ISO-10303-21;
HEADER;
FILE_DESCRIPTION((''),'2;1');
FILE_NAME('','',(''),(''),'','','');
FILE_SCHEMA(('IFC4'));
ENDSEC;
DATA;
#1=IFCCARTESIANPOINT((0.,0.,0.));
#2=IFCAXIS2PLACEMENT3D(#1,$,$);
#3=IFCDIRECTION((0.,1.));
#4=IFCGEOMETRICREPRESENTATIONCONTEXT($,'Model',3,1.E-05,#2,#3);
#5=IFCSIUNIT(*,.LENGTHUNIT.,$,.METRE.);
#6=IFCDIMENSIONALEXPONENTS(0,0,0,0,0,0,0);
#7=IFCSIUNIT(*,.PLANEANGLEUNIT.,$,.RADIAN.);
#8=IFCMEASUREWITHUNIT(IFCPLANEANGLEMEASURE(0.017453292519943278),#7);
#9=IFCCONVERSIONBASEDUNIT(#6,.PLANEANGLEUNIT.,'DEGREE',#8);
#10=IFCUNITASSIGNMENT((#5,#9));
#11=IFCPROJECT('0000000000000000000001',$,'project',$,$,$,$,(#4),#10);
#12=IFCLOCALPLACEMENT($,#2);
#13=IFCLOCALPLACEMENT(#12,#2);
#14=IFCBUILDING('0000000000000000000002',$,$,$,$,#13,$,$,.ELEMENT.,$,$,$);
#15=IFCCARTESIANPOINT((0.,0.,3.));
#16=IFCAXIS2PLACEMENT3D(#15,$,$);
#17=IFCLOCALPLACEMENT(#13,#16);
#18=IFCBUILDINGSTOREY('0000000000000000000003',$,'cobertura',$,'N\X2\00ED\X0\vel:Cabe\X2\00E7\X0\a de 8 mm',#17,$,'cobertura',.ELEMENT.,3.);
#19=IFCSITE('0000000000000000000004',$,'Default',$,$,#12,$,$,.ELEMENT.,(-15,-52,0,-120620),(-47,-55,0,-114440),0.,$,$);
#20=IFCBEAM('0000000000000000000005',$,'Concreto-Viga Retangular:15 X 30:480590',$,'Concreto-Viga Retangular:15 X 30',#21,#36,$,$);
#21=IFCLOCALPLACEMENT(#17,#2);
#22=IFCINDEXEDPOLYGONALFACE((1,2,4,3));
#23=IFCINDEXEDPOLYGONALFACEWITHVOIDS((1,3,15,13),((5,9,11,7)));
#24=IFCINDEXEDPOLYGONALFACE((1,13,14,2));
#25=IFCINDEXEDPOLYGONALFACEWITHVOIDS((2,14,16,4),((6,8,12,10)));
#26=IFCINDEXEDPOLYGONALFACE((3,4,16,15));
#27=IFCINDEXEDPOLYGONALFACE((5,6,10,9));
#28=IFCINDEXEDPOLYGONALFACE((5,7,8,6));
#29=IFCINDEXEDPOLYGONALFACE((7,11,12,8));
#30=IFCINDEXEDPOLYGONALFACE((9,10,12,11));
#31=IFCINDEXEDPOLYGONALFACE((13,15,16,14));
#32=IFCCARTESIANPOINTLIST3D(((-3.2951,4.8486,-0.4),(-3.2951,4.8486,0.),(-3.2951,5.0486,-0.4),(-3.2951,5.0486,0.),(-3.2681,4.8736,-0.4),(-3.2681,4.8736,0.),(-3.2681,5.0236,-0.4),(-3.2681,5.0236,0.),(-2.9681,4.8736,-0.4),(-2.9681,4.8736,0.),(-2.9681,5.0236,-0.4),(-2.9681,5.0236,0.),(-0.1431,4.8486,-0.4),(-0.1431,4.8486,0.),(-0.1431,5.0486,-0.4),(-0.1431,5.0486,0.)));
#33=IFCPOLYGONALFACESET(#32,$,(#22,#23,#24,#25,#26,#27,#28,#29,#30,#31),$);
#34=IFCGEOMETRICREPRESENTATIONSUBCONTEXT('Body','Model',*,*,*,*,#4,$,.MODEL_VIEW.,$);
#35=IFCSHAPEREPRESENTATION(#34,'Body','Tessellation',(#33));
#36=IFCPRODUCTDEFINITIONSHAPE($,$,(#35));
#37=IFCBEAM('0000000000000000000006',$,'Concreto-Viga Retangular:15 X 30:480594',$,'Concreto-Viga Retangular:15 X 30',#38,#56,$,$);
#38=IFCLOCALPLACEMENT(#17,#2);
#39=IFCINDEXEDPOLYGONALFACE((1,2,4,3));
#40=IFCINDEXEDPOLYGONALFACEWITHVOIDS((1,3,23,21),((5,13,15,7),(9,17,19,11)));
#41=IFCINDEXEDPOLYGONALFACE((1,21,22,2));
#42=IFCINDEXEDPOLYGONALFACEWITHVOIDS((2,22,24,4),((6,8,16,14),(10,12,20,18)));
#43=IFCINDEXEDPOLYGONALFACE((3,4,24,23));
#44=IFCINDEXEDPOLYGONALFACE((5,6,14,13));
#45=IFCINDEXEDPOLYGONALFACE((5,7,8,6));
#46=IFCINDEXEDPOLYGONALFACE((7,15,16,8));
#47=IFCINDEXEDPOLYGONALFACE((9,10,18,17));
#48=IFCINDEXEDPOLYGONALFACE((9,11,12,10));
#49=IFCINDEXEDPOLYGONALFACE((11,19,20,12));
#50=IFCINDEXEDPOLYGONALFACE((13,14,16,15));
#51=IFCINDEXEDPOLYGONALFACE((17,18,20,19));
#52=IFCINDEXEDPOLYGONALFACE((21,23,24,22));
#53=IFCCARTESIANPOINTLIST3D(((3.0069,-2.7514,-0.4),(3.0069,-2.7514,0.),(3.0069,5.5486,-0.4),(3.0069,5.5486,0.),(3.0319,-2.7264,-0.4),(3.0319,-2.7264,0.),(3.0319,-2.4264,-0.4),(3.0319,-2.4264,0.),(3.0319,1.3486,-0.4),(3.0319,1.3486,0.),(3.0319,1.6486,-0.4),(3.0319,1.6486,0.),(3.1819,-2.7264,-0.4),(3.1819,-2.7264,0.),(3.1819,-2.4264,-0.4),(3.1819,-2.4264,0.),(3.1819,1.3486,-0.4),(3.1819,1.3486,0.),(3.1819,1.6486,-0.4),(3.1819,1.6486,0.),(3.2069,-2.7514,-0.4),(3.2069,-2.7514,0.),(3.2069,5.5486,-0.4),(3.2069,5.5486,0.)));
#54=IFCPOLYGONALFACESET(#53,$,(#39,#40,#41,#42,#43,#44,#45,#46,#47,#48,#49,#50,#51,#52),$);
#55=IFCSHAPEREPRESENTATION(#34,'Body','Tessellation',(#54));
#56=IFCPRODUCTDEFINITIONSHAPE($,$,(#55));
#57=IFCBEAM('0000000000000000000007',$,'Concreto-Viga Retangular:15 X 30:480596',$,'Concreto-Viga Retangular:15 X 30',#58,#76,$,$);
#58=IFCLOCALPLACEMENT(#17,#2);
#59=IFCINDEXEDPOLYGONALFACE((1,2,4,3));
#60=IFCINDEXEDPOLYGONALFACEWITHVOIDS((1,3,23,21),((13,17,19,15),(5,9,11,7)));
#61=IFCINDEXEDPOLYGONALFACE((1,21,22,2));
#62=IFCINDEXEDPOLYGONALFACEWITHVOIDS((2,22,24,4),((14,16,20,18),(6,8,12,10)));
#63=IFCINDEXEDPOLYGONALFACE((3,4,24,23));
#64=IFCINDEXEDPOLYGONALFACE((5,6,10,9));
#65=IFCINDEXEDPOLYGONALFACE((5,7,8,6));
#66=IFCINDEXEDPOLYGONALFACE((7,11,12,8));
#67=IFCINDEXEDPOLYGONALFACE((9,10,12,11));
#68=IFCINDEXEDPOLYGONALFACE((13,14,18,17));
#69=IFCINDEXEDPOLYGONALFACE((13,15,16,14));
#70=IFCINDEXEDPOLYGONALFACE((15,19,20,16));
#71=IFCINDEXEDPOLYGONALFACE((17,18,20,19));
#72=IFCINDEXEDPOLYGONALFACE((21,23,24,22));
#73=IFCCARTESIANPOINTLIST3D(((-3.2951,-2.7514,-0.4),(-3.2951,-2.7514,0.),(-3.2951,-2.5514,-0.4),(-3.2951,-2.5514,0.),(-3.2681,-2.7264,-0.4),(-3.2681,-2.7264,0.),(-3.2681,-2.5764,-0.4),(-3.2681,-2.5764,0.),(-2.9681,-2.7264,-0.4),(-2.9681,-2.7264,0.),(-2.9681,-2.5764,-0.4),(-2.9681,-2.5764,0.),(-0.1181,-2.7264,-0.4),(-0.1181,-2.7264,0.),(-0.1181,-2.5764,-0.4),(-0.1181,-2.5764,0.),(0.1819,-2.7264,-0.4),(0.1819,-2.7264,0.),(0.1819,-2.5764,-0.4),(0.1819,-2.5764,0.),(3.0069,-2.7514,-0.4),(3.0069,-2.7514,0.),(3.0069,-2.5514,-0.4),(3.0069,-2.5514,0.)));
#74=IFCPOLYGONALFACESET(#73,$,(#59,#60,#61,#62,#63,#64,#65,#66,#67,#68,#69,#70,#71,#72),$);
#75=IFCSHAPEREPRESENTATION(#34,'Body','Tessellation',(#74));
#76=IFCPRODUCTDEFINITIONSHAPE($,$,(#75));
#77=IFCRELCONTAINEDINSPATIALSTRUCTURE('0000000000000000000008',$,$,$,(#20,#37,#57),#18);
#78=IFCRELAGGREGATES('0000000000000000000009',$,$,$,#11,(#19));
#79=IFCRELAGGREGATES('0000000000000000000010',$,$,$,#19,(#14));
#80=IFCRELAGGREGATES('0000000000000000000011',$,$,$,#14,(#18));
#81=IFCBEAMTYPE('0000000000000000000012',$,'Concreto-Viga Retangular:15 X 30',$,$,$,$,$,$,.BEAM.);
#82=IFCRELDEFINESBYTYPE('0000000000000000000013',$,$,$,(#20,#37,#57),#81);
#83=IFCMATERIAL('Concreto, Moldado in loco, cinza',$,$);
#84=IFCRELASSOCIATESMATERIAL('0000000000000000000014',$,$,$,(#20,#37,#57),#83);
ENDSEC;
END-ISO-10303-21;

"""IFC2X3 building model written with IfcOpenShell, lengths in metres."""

from ifc_helpers import new_model, entity, si_unit, converted_unit, direction, frame, frame_2d, origin, origin_2d_with_axis, place, context, subcontext, project, spatial, rectangle, extrude, boolean, material, type_object, element, save


model = new_model("IFC2X3")

# Units and contexts
model_context = context("Model", 3, precision=1e-05, world=origin(), true_north=direction((0.0, 1.0)))
body_context = subcontext(model_context, "Body", "Model", "MODEL_VIEW")
ifc_project = project(units=[si_unit("LENGTHUNIT", "METRE"), converted_unit("PLANEANGLEUNIT", "DEGREE", entity("IfcPlaneAngleMeasure", 0.017453292519943278), si_unit("PLANEANGLEUNIT", "RADIAN"), dimensions=[0, 0, 0, 0, 0, 0, 0])], contexts=[model_context])

# Site, building, storey
site_placement = place(None, origin())
site = spatial("IfcSite", under=ifc_project, at=site_placement, Name="Default", CompositionType="ELEMENT", RefLatitude=(-15, -52, 0, -120620), RefLongitude=(-47, -55, 0, -114440), RefElevation=0.0)
building_placement = place(site_placement, origin())
building = spatial("IfcBuilding", under=site, at=building_placement, CompositionType="ELEMENT")
storey_placement = place(building_placement, frame((0.0, 0.0, 3.0)))
storey = spatial("IfcBuildingStorey", under=building, at=storey_placement, Name="cobertura", ObjectType="Nível:Cabeça de 8 mm", LongName="cobertura", CompositionType="ELEMENT", Elevation=3.0)

# Beams
ifc_material = material(Name="Concreto, Moldado in loco, cinza")
beam_type = type_object("IfcBeamType", Name="Concreto-Viga Retangular:15 X 30", PredefinedType="BEAM")
beam_1_placement = place(storey_placement, frame((-3.1181, 4.9486, 0.0)))
element("IfcBeam", 1, at=beam_1_placement, inside=storey, type_object=beam_type, material=ifc_material, Name="Concreto-Viga Retangular:15 X 30:480590", ObjectType="Concreto-Viga Retangular:15 X 30", context=body_context, shape_type="SweptSolid", body=[
    boolean("DIFFERENCE", extrude(rectangle(XDim=0.4, YDim=0.2, at=frame_2d((0.0, 0.0), x_axis=(1.0, 0.0))), frame((-0.177, 0.0, -0.2), z_axis=(1.0, 0.0, 0.0), x_axis=(0.0, 0.0, -1.0)), (0.0, 0.0, 1.0), 3.152), extrude(rectangle(XDim=0.15, YDim=0.3, at=frame_2d((0.0, 0.0), x_axis=(1.0, 0.0))), frame((0.0, 0.0, -0.4), z_axis=(0.0, 0.0, 1.0), x_axis=(0.0, 1.0, 0.0)), (0.0, 0.0, 1.0), 0.4)),
])
beam_2_placement = place(storey_placement, frame((3.1069, 5.6486, 0.0), z_axis=(0.0, 0.0, 1.0), x_axis=(0.0, -1.0, 0.0)))
element("IfcBeam", 2, at=beam_2_placement, inside=storey, type_object=beam_type, material=ifc_material, Name="Concreto-Viga Retangular:15 X 30:480594", ObjectType="Concreto-Viga Retangular:15 X 30", context=body_context, shape_type="SweptSolid", body=[
    boolean("DIFFERENCE", boolean("DIFFERENCE", extrude(rectangle(XDim=0.4, YDim=0.2, at=frame_2d((0.0, 0.0), x_axis=(1.0, 0.0))), frame((0.1, 0.0, -0.2), z_axis=(1.0, 0.0, 0.0), x_axis=(0.0, 0.0, -1.0)), (0.0, 0.0, 1.0), 8.3), extrude(rectangle(XDim=0.3, YDim=0.15, at=frame_2d((0.0, 0.0), x_axis=(1.0, 0.0))), frame((8.225, 0.0, 0.0), z_axis=(0.0, 0.0, -1.0), x_axis=(1.0, 0.0, 0.0)), (0.0, 0.0, 1.0), 0.4)), extrude(rectangle(XDim=0.3, YDim=0.15, at=frame_2d((0.0, 0.0), x_axis=(1.0, 0.0))), frame((4.15, 0.0, 0.0), z_axis=(0.0, 0.0, -1.0), x_axis=(1.0, 0.0, 0.0)), (0.0, 0.0, 1.0), 0.4)),
])
beam_3_placement = place(storey_placement, frame((-3.1951, -2.6514, 0.0)))
element("IfcBeam", 3, at=beam_3_placement, inside=storey, type_object=beam_type, material=ifc_material, Name="Concreto-Viga Retangular:15 X 30:480596", ObjectType="Concreto-Viga Retangular:15 X 30", context=body_context, shape_type="SweptSolid", body=[
    boolean("DIFFERENCE", boolean("DIFFERENCE", extrude(rectangle(XDim=0.4, YDim=0.2, at=origin_2d_with_axis()), frame((-0.1, 0.0, -0.2), z_axis=(1.0, 0.0, 0.0), x_axis=(0.0, 0.0, -1.0)), (0.0, 0.0, 1.0), 6.302), extrude(rectangle(XDim=0.15, YDim=0.3, at=frame_2d((0.0, 0.0), x_axis=(1.0, 0.0))), frame((0.077, 0.0, 0.0), z_axis=(0.0, 0.0, -1.0), x_axis=(0.0, -1.0, 0.0)), (0.0, 0.0, 1.0), 0.4)), extrude(rectangle(XDim=0.15, YDim=0.3, at=frame_2d((0.0, 0.0), x_axis=(1.0, 0.0))), frame((3.227, 0.0, -0.4), z_axis=(0.0, 0.0, 1.0), x_axis=(0.0, 1.0, 0.0)), (0.0, 0.0, 1.0), 0.4)),
])

save(model, "model.ifc")
